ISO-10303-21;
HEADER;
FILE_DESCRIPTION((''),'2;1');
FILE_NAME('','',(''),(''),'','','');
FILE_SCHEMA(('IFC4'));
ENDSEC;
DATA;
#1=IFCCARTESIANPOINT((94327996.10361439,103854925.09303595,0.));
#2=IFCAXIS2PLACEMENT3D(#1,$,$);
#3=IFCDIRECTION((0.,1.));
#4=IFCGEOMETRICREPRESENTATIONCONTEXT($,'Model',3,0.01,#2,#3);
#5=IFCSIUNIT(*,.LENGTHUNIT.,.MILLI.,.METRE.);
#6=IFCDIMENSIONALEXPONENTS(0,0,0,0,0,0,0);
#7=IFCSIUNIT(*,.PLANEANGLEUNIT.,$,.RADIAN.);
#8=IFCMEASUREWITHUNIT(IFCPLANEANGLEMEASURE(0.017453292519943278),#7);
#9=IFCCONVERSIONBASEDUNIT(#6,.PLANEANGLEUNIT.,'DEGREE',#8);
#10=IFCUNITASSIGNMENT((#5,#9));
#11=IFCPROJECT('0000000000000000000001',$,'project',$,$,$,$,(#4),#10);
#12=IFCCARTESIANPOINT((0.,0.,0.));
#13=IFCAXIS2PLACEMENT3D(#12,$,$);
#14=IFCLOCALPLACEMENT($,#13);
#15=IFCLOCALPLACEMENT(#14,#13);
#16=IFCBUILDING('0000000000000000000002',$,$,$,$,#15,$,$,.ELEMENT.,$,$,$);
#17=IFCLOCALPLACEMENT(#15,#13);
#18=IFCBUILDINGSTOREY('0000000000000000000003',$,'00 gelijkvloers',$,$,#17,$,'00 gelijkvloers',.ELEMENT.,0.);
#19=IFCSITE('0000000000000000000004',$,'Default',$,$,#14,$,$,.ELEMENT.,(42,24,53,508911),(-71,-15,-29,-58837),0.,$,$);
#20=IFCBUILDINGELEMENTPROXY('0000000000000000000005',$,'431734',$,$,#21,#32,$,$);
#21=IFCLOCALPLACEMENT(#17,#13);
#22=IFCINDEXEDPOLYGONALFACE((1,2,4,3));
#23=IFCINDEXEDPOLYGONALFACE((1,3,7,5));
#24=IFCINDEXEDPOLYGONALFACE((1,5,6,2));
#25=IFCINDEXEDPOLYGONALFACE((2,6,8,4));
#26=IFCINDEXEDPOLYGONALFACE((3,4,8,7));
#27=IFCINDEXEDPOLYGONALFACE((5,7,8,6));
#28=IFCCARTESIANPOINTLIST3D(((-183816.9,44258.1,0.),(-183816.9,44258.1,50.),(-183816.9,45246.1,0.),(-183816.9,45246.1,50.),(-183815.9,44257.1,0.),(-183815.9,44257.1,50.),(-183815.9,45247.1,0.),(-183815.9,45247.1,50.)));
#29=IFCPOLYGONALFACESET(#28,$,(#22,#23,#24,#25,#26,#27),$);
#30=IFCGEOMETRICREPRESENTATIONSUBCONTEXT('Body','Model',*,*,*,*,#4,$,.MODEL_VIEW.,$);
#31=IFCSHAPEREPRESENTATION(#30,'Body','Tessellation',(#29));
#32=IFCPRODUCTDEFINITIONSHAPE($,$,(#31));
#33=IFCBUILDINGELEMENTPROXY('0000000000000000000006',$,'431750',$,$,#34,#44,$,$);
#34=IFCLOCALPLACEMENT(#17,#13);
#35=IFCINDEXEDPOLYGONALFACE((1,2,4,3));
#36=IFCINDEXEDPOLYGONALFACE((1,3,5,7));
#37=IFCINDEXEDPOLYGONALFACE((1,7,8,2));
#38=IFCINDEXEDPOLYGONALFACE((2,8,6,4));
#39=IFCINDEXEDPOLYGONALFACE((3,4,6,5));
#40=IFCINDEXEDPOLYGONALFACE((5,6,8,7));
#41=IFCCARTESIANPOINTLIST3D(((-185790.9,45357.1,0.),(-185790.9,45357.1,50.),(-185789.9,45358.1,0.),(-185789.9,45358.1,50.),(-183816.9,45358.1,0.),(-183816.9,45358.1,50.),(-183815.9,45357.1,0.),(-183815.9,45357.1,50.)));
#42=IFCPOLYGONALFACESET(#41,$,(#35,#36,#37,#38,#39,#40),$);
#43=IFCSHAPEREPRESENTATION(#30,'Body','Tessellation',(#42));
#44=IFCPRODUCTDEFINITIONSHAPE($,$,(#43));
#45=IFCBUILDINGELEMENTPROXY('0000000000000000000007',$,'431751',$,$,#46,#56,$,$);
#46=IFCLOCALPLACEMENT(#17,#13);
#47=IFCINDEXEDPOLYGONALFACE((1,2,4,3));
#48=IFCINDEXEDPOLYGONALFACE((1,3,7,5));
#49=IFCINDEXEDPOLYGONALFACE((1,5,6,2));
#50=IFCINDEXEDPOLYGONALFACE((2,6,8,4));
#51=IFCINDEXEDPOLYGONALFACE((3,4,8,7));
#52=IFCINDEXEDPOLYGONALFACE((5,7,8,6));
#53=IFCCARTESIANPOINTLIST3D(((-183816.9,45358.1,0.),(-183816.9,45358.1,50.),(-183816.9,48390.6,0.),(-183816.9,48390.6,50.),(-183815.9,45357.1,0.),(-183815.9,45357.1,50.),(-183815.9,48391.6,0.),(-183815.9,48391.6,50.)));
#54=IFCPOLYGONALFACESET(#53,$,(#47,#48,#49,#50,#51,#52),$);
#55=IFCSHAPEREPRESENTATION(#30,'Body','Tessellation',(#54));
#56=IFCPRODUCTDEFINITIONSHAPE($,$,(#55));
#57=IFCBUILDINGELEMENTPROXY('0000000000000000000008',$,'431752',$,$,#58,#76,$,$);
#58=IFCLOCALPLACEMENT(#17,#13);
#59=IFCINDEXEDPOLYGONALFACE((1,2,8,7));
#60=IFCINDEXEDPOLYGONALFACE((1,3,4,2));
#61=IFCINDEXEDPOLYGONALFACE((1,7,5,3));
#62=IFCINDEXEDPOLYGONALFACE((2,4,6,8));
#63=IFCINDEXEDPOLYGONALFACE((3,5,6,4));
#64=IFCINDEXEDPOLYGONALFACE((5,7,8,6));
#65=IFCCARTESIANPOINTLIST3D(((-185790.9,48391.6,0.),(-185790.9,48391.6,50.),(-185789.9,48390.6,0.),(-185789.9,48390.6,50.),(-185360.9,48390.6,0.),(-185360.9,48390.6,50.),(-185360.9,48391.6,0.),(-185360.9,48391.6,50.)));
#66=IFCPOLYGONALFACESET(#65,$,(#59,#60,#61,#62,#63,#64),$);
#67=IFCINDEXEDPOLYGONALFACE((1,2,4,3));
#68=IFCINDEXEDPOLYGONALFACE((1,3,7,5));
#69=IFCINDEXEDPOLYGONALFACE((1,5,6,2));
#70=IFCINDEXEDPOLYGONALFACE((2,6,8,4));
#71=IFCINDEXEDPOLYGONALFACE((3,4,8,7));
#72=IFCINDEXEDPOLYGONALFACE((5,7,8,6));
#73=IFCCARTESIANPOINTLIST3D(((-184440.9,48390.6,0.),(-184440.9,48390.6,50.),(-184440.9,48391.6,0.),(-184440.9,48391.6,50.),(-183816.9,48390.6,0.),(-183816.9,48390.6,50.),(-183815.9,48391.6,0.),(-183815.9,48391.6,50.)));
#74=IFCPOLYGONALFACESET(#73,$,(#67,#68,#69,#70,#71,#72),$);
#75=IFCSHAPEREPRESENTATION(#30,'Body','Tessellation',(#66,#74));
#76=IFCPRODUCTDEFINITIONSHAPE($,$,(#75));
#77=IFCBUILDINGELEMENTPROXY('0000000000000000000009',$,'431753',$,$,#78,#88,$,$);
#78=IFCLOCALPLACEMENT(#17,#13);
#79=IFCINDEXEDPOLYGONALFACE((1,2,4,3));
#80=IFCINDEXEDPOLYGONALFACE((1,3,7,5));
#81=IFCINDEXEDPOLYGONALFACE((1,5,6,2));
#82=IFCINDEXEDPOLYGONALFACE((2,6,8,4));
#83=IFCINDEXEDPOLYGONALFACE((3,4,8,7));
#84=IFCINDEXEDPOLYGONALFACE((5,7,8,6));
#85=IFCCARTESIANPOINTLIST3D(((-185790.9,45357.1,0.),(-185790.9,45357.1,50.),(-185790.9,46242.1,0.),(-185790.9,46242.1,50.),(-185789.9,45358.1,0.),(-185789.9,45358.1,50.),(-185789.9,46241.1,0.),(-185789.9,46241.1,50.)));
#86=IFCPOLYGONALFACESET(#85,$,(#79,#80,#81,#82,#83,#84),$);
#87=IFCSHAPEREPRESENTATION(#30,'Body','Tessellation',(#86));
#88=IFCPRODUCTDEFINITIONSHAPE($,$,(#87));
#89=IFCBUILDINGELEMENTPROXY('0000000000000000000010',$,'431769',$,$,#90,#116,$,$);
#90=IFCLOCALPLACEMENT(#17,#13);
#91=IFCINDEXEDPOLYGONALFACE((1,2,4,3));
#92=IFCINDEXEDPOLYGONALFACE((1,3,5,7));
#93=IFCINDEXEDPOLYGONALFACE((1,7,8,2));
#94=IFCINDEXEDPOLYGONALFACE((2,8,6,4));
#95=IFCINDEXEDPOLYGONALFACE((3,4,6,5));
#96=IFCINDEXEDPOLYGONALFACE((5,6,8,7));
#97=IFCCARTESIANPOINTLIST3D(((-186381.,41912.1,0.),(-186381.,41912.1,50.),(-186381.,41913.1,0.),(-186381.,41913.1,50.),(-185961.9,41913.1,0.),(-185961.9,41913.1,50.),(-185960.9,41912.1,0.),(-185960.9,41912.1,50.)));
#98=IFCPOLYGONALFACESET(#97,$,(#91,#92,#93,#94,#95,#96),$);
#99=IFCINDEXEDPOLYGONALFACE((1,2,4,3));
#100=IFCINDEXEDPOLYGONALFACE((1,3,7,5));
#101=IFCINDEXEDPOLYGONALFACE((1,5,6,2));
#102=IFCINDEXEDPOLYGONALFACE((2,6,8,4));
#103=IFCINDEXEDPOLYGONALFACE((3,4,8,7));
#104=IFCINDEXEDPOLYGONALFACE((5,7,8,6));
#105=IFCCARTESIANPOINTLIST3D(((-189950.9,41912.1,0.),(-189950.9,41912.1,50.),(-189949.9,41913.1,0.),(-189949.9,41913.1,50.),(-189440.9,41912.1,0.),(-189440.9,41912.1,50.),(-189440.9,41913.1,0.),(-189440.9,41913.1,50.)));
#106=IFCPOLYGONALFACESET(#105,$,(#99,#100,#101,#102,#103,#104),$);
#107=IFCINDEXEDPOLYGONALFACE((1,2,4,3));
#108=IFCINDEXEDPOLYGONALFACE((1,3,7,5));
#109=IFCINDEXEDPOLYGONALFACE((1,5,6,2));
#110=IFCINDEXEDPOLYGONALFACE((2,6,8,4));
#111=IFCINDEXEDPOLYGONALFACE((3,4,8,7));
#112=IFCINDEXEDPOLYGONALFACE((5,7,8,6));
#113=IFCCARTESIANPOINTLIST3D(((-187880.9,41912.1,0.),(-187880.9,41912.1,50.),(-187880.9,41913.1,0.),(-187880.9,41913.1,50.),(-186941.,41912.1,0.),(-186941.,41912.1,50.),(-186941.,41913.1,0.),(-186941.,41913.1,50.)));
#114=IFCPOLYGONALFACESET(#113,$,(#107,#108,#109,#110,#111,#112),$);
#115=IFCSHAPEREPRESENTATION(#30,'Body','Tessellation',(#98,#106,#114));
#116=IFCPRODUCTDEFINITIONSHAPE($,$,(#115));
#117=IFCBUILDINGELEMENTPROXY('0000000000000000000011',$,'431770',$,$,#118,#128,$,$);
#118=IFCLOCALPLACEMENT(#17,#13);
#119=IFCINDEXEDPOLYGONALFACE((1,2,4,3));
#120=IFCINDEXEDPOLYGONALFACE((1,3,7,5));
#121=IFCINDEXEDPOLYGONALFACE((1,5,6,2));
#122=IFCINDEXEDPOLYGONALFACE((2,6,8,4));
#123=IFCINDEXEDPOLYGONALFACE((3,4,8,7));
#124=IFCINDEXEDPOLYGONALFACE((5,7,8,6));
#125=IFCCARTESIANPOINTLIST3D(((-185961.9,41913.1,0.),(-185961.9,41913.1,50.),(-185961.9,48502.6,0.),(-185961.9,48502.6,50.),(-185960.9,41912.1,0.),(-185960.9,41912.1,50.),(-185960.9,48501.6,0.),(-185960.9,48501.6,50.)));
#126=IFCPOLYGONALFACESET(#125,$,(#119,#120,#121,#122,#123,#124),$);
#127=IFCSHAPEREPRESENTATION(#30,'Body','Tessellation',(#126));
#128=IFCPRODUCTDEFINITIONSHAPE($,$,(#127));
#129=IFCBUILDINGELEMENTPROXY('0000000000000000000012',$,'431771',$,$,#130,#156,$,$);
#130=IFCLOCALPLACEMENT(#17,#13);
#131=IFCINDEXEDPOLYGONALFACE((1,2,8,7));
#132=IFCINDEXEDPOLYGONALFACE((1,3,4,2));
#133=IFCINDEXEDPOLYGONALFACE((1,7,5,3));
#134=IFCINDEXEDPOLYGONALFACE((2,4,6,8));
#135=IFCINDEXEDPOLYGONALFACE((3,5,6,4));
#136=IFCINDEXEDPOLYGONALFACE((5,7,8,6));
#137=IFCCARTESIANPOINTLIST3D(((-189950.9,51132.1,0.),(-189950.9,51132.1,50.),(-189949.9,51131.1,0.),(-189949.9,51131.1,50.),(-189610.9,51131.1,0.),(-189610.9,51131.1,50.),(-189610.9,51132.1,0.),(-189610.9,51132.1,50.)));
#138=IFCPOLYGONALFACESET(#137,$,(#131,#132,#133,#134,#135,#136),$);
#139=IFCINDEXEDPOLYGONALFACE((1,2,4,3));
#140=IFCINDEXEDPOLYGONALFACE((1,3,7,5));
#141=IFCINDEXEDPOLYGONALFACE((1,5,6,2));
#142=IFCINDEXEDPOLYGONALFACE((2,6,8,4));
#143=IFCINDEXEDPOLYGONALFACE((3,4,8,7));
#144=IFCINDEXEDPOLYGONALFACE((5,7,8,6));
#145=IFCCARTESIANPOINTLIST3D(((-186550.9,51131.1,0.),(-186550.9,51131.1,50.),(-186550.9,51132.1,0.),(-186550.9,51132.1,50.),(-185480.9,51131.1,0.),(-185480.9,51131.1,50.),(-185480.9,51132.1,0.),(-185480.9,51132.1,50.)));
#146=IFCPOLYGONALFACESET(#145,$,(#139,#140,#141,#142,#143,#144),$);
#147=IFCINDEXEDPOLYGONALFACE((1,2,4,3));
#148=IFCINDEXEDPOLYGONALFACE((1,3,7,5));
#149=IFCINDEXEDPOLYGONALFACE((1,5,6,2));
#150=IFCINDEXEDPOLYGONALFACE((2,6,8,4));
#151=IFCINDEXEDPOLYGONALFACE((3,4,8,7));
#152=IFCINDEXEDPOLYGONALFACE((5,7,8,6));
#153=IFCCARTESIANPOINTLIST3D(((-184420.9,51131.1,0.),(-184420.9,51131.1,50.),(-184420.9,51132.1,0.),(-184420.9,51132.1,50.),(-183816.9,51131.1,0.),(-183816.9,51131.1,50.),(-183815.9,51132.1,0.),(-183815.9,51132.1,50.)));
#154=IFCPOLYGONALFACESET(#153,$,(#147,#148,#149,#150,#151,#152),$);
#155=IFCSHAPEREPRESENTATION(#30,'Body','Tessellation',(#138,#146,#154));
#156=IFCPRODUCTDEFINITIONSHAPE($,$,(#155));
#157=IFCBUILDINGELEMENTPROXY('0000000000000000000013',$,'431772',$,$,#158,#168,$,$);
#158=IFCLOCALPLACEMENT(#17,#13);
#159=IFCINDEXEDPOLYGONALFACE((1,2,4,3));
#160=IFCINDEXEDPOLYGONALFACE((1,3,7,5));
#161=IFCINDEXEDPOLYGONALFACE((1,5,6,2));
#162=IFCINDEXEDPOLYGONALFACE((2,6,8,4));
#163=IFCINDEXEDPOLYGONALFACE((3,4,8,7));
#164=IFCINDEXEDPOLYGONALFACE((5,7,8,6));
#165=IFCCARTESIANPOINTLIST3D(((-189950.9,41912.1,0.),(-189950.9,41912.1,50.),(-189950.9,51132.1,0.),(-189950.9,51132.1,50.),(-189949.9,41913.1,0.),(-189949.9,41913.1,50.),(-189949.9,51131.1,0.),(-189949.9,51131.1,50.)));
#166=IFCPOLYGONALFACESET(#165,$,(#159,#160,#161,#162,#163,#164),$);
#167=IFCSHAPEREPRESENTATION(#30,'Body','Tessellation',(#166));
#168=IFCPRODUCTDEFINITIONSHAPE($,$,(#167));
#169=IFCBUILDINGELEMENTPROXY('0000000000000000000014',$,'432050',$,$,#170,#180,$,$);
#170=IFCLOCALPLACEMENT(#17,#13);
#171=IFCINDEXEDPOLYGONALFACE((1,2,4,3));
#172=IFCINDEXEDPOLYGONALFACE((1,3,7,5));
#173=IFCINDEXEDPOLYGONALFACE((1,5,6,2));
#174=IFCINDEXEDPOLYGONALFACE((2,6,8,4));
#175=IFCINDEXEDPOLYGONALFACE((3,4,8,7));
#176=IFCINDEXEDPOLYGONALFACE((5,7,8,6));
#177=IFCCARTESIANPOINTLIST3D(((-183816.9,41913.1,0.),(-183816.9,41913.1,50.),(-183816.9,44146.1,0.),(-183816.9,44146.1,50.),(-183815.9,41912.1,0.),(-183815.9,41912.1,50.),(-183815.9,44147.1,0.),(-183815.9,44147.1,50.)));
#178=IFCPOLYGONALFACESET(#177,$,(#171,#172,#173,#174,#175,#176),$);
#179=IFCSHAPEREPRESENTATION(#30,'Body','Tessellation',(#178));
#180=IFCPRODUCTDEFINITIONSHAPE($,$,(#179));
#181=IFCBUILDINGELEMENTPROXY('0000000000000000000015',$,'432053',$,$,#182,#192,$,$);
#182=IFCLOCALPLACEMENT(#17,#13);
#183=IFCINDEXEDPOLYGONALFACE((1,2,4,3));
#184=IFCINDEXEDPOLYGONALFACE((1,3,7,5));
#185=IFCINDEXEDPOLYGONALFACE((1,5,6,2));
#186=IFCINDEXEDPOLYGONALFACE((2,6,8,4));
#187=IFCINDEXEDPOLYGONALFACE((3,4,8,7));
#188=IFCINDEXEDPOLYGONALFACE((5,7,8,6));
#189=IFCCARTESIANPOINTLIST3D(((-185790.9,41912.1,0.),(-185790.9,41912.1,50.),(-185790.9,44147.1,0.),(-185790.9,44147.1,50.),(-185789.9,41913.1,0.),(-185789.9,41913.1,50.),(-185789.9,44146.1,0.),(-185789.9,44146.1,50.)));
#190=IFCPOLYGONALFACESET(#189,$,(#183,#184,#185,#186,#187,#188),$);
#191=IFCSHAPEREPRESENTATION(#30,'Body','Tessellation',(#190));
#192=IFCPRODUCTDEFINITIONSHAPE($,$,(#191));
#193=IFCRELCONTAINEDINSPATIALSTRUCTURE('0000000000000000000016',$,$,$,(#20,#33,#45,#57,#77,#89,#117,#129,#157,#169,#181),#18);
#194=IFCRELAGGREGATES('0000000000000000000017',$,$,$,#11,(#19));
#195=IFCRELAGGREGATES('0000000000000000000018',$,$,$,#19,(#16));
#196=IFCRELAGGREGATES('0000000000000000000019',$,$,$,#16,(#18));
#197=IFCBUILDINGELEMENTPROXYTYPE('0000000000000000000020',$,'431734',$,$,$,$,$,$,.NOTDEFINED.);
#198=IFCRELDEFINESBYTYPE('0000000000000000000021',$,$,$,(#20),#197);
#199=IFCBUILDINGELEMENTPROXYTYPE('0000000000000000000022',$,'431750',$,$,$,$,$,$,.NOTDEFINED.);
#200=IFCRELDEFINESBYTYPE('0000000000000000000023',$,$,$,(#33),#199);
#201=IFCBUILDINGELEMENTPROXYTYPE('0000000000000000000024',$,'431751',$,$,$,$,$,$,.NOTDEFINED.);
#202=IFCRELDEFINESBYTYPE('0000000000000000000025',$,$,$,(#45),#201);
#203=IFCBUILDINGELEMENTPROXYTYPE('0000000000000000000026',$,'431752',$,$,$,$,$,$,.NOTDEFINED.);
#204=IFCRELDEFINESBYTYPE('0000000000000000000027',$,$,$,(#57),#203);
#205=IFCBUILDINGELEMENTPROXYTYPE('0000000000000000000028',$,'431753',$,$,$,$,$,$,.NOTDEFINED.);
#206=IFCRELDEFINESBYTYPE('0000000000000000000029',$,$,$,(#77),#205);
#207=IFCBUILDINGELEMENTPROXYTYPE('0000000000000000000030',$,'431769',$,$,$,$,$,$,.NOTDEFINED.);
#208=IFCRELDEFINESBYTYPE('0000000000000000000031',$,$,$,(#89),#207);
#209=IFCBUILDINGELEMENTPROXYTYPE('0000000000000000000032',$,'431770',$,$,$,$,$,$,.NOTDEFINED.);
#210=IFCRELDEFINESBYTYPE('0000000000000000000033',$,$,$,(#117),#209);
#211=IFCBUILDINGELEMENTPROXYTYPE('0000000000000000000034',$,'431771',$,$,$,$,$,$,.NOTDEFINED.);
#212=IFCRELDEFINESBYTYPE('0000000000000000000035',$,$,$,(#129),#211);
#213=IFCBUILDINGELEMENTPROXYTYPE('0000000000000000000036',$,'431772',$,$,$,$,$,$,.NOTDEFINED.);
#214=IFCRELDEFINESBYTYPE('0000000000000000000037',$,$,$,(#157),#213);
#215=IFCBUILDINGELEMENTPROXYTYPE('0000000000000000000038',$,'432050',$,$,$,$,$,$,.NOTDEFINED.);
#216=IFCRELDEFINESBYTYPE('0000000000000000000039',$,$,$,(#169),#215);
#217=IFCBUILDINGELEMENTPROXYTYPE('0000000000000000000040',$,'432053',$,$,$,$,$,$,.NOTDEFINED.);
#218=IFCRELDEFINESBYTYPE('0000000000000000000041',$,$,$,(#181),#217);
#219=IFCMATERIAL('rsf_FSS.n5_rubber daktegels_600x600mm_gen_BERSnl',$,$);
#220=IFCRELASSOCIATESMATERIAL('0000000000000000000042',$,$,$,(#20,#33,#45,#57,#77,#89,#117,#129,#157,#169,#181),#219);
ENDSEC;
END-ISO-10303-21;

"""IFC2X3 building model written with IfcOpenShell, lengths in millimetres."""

from ifc_helpers import new_model, entity, si_unit, converted_unit, direction, frame, origin, origin_2d_with_axis, place, context, subcontext, project, spatial, polyline, rectangle, outline, extrude, material, type_object, element, save


model = new_model("IFC2X3")

# Units and contexts
model_context = context("Model", 3, precision=0.01, world=frame((94327996.10361439, 103854925.09303595, 0.0)), true_north=direction((0.0, 1.0)))
body_context = subcontext(model_context, "Body", "Model", "MODEL_VIEW")
ifc_project = project(units=[si_unit("LENGTHUNIT", "METRE", prefix="MILLI"), converted_unit("PLANEANGLEUNIT", "DEGREE", entity("IfcPlaneAngleMeasure", 0.017453292519943278), si_unit("PLANEANGLEUNIT", "RADIAN"), dimensions=[0, 0, 0, 0, 0, 0, 0])], contexts=[model_context])

# Site, building, storey
site_placement = place(None, origin())
site = spatial("IfcSite", under=ifc_project, at=site_placement, Name="Default", CompositionType="ELEMENT", RefLatitude=(42, 24, 53, 508911), RefLongitude=(-71, -15, -29, -58837), RefElevation=0.0)
building_placement = place(site_placement, origin())
building = spatial("IfcBuilding", under=site, at=building_placement, CompositionType="ELEMENT")
storey_placement = place(building_placement, origin())
storey = spatial("IfcBuildingStorey", under=building, at=storey_placement, Name="00 gelijkvloers", LongName="00 gelijkvloers", CompositionType="ELEMENT", Elevation=0.0)

# Building element proxies
ifc_material = material(Name="rsf_FSS.n5_rubber daktegels_600x600mm_gen_BERSnl")
building_element_proxy_type_1 = type_object("IfcBuildingElementProxyType", Name="431734", PredefinedType="NOTDEFINED")
proxy_1_placement = place(storey_placement, origin())
element("IfcBuildingElementProxy", 1, at=proxy_1_placement, inside=storey, type_object=building_element_proxy_type_1, material=ifc_material, Name="431734", context=body_context, shape_type="SweptSolid", body=[
    extrude(outline(polyline([(-494.0, -0.5), (494.0, -0.5), (495.0, 0.5), (-495.0, 0.5), (-494.0, -0.5)])), frame((-183816.4, 44752.1, 0.0), z_axis=(0.0, 0.0, 1.0), x_axis=(0.0, -1.0, 0.0)), (0.0, 0.0, 1.0), 50.0),
])
building_element_proxy_type_2 = type_object("IfcBuildingElementProxyType", Name="431750", PredefinedType="NOTDEFINED")
proxy_2_placement = place(storey_placement, origin())
element("IfcBuildingElementProxy", 2, at=proxy_2_placement, inside=storey, type_object=building_element_proxy_type_2, material=ifc_material, Name="431750", context=body_context, shape_type="SweptSolid", body=[
    extrude(outline(polyline([(-986.5, -0.5), (986.5, -0.5), (987.5, 0.5), (-987.5, 0.5), (-986.5, -0.5)])), frame((-184803.4, 45357.6, 0.0), z_axis=(0.0, 0.0, 1.0), x_axis=(-1.0, 0.0, 0.0)), (0.0, 0.0, 1.0), 50.0),
])
building_element_proxy_type_3 = type_object("IfcBuildingElementProxyType", Name="431751", PredefinedType="NOTDEFINED")
proxy_3_placement = place(storey_placement, origin())
element("IfcBuildingElementProxy", 3, at=proxy_3_placement, inside=storey, type_object=building_element_proxy_type_3, material=ifc_material, Name="431751", context=body_context, shape_type="SweptSolid", body=[
    extrude(outline(polyline([(-1516.3, -0.5), (1516.3, -0.5), (1517.3, 0.5), (-1517.3, 0.5), (-1516.3, -0.5)])), frame((-183816.4, 46874.3, 0.0), z_axis=(0.0, 0.0, 1.0), x_axis=(0.0, -1.0, 0.0)), (0.0, 0.0, 1.0), 50.0),
])
building_element_proxy_type_4 = type_object("IfcBuildingElementProxyType", Name="431752", PredefinedType="NOTDEFINED")
proxy_4_placement = place(storey_placement, origin())
element("IfcBuildingElementProxy", 4, at=proxy_4_placement, inside=storey, type_object=building_element_proxy_type_4, material=ifc_material, Name="431752", context=body_context, shape_type="SweptSolid", body=[
    extrude(outline(polyline([(-214.2, -0.5), (214.7, -0.5), (214.7, 0.5), (-215.2, 0.5), (-214.2, -0.5)])), frame((-185575.6, 48391.1, 0.0)), (0.0, 0.0, 1.0), 50.0),
    extrude(outline(polyline([(-312.3, -0.5), (311.8, -0.5), (312.8, 0.5), (-312.3, 0.5), (-312.3, -0.5)])), frame((-184128.6, 48391.1, 0.0)), (0.0, 0.0, 1.0), 50.0),
])
building_element_proxy_type_5 = type_object("IfcBuildingElementProxyType", Name="431753", PredefinedType="NOTDEFINED")
proxy_5_placement = place(storey_placement, origin())
element("IfcBuildingElementProxy", 5, at=proxy_5_placement, inside=storey, type_object=building_element_proxy_type_5, material=ifc_material, Name="431753", context=body_context, shape_type="SweptSolid", body=[
    extrude(outline(polyline([(-441.5, -0.5), (441.5, -0.5), (442.5, 0.5), (-442.5, 0.5), (-441.5, -0.5)])), frame((-185790.4, 45799.6, 0.0), z_axis=(0.0, 0.0, 1.0), x_axis=(0.0, 1.0, 0.0)), (0.0, 0.0, 1.0), 50.0),
])
building_element_proxy_type_6 = type_object("IfcBuildingElementProxyType", Name="431769", PredefinedType="NOTDEFINED")
proxy_6_placement = place(storey_placement, origin())
element("IfcBuildingElementProxy", 6, at=proxy_6_placement, inside=storey, type_object=building_element_proxy_type_6, material=ifc_material, Name="431769", context=body_context, shape_type="SweptSolid", body=[
    extrude(outline(polyline([(-209.3, -0.5), (209.8, -0.5), (209.8, 0.5), (-210.3, 0.5), (-209.3, -0.5)])), frame((-186171.2, 41912.6, 0.0), z_axis=(0.0, 0.0, 1.0), x_axis=(-1.0, 0.0, 0.0)), (0.0, 0.0, 1.0), 50.0),
    extrude(outline(polyline([(-254.7, -0.5), (254.3, -0.5), (255.2, 0.5), (-254.7, 0.5), (-254.7, -0.5)])), frame((-189695.6, 41912.6, 0.0), z_axis=(0.0, 0.0, 1.0), x_axis=(-1.0, 0.0, 0.0)), (0.0, 0.0, 1.0), 50.0),
    extrude(rectangle(XDim=939.8, YDim=1.0, at=origin_2d_with_axis()), frame((-187411.0, 41912.6, 0.0), z_axis=(0.0, 0.0, 1.0), x_axis=(-1.0, 0.0, 0.0)), (0.0, 0.0, 1.0), 50.0),
])
building_element_proxy_type_7 = type_object("IfcBuildingElementProxyType", Name="431770", PredefinedType="NOTDEFINED")
proxy_7_placement = place(storey_placement, origin())
element("IfcBuildingElementProxy", 7, at=proxy_7_placement, inside=storey, type_object=building_element_proxy_type_7, material=ifc_material, Name="431770", context=body_context, shape_type="SweptSolid", body=[
    extrude(outline(polyline([(-3295.3, -0.5), (3294.3, -0.5), (3295.3, 0.5), (-3294.3, 0.5), (-3295.3, -0.5)])), frame((-185961.4, 45207.3, 0.0), z_axis=(0.0, 0.0, 1.0), x_axis=(0.0, -1.0, 0.0)), (0.0, 0.0, 1.0), 50.0),
])
building_element_proxy_type_8 = type_object("IfcBuildingElementProxyType", Name="431771", PredefinedType="NOTDEFINED")
proxy_8_placement = place(storey_placement, origin())
element("IfcBuildingElementProxy", 8, at=proxy_8_placement, inside=storey, type_object=building_element_proxy_type_8, material=ifc_material, Name="431771", context=body_context, shape_type="SweptSolid", body=[
    extrude(outline(polyline([(-169.2, -0.5), (169.7, -0.5), (169.7, 0.5), (-170.2, 0.5), (-169.2, -0.5)])), frame((-189780.6, 51131.6, 0.0)), (0.0, 0.0, 1.0), 50.0),
    extrude(rectangle(XDim=1070.0, YDim=1.0, at=origin_2d_with_axis()), frame((-186015.9, 51131.6, 0.0)), (0.0, 0.0, 1.0), 50.0),
    extrude(outline(polyline([(-302.3, -0.5), (301.8, -0.5), (302.8, 0.5), (-302.3, 0.5), (-302.3, -0.5)])), frame((-184118.6, 51131.6, 0.0)), (0.0, 0.0, 1.0), 50.0),
])
building_element_proxy_type_9 = type_object("IfcBuildingElementProxyType", Name="431772", PredefinedType="NOTDEFINED")
proxy_9_placement = place(storey_placement, origin())
element("IfcBuildingElementProxy", 9, at=proxy_9_placement, inside=storey, type_object=building_element_proxy_type_9, material=ifc_material, Name="431772", context=body_context, shape_type="SweptSolid", body=[
    extrude(outline(polyline([(-4609.0, -0.5), (4609.0, -0.5), (4610.0, 0.5), (-4610.0, 0.5), (-4609.0, -0.5)])), frame((-189950.4, 46522.1, 0.0), z_axis=(0.0, 0.0, 1.0), x_axis=(0.0, 1.0, 0.0)), (0.0, 0.0, 1.0), 50.0),
])
building_element_proxy_type_10 = type_object("IfcBuildingElementProxyType", Name="432050", PredefinedType="NOTDEFINED")
proxy_10_placement = place(storey_placement, origin())
element("IfcBuildingElementProxy", 10, at=proxy_10_placement, inside=storey, type_object=building_element_proxy_type_10, material=ifc_material, Name="432050", context=body_context, shape_type="SweptSolid", body=[
    extrude(outline(polyline([(-1116.5, -0.5), (1116.5, -0.5), (1117.5, 0.5), (-1117.5, 0.5), (-1116.5, -0.5)])), frame((-183816.4, 43029.6, 0.0), z_axis=(0.0, 0.0, 1.0), x_axis=(0.0, -1.0, 0.0)), (0.0, 0.0, 1.0), 50.0),
])
building_element_proxy_type_11 = type_object("IfcBuildingElementProxyType", Name="432053", PredefinedType="NOTDEFINED")
proxy_11_placement = place(storey_placement, origin())
element("IfcBuildingElementProxy", 11, at=proxy_11_placement, inside=storey, type_object=building_element_proxy_type_11, material=ifc_material, Name="432053", context=body_context, shape_type="SweptSolid", body=[
    extrude(outline(polyline([(-1116.5, -0.5), (1116.5, -0.5), (1117.5, 0.5), (-1117.5, 0.5), (-1116.5, -0.5)])), frame((-185790.4, 43029.6, 0.0), z_axis=(0.0, 0.0, 1.0), x_axis=(0.0, 1.0, 0.0)), (0.0, 0.0, 1.0), 50.0),
])

save(model, "model.ifc")
